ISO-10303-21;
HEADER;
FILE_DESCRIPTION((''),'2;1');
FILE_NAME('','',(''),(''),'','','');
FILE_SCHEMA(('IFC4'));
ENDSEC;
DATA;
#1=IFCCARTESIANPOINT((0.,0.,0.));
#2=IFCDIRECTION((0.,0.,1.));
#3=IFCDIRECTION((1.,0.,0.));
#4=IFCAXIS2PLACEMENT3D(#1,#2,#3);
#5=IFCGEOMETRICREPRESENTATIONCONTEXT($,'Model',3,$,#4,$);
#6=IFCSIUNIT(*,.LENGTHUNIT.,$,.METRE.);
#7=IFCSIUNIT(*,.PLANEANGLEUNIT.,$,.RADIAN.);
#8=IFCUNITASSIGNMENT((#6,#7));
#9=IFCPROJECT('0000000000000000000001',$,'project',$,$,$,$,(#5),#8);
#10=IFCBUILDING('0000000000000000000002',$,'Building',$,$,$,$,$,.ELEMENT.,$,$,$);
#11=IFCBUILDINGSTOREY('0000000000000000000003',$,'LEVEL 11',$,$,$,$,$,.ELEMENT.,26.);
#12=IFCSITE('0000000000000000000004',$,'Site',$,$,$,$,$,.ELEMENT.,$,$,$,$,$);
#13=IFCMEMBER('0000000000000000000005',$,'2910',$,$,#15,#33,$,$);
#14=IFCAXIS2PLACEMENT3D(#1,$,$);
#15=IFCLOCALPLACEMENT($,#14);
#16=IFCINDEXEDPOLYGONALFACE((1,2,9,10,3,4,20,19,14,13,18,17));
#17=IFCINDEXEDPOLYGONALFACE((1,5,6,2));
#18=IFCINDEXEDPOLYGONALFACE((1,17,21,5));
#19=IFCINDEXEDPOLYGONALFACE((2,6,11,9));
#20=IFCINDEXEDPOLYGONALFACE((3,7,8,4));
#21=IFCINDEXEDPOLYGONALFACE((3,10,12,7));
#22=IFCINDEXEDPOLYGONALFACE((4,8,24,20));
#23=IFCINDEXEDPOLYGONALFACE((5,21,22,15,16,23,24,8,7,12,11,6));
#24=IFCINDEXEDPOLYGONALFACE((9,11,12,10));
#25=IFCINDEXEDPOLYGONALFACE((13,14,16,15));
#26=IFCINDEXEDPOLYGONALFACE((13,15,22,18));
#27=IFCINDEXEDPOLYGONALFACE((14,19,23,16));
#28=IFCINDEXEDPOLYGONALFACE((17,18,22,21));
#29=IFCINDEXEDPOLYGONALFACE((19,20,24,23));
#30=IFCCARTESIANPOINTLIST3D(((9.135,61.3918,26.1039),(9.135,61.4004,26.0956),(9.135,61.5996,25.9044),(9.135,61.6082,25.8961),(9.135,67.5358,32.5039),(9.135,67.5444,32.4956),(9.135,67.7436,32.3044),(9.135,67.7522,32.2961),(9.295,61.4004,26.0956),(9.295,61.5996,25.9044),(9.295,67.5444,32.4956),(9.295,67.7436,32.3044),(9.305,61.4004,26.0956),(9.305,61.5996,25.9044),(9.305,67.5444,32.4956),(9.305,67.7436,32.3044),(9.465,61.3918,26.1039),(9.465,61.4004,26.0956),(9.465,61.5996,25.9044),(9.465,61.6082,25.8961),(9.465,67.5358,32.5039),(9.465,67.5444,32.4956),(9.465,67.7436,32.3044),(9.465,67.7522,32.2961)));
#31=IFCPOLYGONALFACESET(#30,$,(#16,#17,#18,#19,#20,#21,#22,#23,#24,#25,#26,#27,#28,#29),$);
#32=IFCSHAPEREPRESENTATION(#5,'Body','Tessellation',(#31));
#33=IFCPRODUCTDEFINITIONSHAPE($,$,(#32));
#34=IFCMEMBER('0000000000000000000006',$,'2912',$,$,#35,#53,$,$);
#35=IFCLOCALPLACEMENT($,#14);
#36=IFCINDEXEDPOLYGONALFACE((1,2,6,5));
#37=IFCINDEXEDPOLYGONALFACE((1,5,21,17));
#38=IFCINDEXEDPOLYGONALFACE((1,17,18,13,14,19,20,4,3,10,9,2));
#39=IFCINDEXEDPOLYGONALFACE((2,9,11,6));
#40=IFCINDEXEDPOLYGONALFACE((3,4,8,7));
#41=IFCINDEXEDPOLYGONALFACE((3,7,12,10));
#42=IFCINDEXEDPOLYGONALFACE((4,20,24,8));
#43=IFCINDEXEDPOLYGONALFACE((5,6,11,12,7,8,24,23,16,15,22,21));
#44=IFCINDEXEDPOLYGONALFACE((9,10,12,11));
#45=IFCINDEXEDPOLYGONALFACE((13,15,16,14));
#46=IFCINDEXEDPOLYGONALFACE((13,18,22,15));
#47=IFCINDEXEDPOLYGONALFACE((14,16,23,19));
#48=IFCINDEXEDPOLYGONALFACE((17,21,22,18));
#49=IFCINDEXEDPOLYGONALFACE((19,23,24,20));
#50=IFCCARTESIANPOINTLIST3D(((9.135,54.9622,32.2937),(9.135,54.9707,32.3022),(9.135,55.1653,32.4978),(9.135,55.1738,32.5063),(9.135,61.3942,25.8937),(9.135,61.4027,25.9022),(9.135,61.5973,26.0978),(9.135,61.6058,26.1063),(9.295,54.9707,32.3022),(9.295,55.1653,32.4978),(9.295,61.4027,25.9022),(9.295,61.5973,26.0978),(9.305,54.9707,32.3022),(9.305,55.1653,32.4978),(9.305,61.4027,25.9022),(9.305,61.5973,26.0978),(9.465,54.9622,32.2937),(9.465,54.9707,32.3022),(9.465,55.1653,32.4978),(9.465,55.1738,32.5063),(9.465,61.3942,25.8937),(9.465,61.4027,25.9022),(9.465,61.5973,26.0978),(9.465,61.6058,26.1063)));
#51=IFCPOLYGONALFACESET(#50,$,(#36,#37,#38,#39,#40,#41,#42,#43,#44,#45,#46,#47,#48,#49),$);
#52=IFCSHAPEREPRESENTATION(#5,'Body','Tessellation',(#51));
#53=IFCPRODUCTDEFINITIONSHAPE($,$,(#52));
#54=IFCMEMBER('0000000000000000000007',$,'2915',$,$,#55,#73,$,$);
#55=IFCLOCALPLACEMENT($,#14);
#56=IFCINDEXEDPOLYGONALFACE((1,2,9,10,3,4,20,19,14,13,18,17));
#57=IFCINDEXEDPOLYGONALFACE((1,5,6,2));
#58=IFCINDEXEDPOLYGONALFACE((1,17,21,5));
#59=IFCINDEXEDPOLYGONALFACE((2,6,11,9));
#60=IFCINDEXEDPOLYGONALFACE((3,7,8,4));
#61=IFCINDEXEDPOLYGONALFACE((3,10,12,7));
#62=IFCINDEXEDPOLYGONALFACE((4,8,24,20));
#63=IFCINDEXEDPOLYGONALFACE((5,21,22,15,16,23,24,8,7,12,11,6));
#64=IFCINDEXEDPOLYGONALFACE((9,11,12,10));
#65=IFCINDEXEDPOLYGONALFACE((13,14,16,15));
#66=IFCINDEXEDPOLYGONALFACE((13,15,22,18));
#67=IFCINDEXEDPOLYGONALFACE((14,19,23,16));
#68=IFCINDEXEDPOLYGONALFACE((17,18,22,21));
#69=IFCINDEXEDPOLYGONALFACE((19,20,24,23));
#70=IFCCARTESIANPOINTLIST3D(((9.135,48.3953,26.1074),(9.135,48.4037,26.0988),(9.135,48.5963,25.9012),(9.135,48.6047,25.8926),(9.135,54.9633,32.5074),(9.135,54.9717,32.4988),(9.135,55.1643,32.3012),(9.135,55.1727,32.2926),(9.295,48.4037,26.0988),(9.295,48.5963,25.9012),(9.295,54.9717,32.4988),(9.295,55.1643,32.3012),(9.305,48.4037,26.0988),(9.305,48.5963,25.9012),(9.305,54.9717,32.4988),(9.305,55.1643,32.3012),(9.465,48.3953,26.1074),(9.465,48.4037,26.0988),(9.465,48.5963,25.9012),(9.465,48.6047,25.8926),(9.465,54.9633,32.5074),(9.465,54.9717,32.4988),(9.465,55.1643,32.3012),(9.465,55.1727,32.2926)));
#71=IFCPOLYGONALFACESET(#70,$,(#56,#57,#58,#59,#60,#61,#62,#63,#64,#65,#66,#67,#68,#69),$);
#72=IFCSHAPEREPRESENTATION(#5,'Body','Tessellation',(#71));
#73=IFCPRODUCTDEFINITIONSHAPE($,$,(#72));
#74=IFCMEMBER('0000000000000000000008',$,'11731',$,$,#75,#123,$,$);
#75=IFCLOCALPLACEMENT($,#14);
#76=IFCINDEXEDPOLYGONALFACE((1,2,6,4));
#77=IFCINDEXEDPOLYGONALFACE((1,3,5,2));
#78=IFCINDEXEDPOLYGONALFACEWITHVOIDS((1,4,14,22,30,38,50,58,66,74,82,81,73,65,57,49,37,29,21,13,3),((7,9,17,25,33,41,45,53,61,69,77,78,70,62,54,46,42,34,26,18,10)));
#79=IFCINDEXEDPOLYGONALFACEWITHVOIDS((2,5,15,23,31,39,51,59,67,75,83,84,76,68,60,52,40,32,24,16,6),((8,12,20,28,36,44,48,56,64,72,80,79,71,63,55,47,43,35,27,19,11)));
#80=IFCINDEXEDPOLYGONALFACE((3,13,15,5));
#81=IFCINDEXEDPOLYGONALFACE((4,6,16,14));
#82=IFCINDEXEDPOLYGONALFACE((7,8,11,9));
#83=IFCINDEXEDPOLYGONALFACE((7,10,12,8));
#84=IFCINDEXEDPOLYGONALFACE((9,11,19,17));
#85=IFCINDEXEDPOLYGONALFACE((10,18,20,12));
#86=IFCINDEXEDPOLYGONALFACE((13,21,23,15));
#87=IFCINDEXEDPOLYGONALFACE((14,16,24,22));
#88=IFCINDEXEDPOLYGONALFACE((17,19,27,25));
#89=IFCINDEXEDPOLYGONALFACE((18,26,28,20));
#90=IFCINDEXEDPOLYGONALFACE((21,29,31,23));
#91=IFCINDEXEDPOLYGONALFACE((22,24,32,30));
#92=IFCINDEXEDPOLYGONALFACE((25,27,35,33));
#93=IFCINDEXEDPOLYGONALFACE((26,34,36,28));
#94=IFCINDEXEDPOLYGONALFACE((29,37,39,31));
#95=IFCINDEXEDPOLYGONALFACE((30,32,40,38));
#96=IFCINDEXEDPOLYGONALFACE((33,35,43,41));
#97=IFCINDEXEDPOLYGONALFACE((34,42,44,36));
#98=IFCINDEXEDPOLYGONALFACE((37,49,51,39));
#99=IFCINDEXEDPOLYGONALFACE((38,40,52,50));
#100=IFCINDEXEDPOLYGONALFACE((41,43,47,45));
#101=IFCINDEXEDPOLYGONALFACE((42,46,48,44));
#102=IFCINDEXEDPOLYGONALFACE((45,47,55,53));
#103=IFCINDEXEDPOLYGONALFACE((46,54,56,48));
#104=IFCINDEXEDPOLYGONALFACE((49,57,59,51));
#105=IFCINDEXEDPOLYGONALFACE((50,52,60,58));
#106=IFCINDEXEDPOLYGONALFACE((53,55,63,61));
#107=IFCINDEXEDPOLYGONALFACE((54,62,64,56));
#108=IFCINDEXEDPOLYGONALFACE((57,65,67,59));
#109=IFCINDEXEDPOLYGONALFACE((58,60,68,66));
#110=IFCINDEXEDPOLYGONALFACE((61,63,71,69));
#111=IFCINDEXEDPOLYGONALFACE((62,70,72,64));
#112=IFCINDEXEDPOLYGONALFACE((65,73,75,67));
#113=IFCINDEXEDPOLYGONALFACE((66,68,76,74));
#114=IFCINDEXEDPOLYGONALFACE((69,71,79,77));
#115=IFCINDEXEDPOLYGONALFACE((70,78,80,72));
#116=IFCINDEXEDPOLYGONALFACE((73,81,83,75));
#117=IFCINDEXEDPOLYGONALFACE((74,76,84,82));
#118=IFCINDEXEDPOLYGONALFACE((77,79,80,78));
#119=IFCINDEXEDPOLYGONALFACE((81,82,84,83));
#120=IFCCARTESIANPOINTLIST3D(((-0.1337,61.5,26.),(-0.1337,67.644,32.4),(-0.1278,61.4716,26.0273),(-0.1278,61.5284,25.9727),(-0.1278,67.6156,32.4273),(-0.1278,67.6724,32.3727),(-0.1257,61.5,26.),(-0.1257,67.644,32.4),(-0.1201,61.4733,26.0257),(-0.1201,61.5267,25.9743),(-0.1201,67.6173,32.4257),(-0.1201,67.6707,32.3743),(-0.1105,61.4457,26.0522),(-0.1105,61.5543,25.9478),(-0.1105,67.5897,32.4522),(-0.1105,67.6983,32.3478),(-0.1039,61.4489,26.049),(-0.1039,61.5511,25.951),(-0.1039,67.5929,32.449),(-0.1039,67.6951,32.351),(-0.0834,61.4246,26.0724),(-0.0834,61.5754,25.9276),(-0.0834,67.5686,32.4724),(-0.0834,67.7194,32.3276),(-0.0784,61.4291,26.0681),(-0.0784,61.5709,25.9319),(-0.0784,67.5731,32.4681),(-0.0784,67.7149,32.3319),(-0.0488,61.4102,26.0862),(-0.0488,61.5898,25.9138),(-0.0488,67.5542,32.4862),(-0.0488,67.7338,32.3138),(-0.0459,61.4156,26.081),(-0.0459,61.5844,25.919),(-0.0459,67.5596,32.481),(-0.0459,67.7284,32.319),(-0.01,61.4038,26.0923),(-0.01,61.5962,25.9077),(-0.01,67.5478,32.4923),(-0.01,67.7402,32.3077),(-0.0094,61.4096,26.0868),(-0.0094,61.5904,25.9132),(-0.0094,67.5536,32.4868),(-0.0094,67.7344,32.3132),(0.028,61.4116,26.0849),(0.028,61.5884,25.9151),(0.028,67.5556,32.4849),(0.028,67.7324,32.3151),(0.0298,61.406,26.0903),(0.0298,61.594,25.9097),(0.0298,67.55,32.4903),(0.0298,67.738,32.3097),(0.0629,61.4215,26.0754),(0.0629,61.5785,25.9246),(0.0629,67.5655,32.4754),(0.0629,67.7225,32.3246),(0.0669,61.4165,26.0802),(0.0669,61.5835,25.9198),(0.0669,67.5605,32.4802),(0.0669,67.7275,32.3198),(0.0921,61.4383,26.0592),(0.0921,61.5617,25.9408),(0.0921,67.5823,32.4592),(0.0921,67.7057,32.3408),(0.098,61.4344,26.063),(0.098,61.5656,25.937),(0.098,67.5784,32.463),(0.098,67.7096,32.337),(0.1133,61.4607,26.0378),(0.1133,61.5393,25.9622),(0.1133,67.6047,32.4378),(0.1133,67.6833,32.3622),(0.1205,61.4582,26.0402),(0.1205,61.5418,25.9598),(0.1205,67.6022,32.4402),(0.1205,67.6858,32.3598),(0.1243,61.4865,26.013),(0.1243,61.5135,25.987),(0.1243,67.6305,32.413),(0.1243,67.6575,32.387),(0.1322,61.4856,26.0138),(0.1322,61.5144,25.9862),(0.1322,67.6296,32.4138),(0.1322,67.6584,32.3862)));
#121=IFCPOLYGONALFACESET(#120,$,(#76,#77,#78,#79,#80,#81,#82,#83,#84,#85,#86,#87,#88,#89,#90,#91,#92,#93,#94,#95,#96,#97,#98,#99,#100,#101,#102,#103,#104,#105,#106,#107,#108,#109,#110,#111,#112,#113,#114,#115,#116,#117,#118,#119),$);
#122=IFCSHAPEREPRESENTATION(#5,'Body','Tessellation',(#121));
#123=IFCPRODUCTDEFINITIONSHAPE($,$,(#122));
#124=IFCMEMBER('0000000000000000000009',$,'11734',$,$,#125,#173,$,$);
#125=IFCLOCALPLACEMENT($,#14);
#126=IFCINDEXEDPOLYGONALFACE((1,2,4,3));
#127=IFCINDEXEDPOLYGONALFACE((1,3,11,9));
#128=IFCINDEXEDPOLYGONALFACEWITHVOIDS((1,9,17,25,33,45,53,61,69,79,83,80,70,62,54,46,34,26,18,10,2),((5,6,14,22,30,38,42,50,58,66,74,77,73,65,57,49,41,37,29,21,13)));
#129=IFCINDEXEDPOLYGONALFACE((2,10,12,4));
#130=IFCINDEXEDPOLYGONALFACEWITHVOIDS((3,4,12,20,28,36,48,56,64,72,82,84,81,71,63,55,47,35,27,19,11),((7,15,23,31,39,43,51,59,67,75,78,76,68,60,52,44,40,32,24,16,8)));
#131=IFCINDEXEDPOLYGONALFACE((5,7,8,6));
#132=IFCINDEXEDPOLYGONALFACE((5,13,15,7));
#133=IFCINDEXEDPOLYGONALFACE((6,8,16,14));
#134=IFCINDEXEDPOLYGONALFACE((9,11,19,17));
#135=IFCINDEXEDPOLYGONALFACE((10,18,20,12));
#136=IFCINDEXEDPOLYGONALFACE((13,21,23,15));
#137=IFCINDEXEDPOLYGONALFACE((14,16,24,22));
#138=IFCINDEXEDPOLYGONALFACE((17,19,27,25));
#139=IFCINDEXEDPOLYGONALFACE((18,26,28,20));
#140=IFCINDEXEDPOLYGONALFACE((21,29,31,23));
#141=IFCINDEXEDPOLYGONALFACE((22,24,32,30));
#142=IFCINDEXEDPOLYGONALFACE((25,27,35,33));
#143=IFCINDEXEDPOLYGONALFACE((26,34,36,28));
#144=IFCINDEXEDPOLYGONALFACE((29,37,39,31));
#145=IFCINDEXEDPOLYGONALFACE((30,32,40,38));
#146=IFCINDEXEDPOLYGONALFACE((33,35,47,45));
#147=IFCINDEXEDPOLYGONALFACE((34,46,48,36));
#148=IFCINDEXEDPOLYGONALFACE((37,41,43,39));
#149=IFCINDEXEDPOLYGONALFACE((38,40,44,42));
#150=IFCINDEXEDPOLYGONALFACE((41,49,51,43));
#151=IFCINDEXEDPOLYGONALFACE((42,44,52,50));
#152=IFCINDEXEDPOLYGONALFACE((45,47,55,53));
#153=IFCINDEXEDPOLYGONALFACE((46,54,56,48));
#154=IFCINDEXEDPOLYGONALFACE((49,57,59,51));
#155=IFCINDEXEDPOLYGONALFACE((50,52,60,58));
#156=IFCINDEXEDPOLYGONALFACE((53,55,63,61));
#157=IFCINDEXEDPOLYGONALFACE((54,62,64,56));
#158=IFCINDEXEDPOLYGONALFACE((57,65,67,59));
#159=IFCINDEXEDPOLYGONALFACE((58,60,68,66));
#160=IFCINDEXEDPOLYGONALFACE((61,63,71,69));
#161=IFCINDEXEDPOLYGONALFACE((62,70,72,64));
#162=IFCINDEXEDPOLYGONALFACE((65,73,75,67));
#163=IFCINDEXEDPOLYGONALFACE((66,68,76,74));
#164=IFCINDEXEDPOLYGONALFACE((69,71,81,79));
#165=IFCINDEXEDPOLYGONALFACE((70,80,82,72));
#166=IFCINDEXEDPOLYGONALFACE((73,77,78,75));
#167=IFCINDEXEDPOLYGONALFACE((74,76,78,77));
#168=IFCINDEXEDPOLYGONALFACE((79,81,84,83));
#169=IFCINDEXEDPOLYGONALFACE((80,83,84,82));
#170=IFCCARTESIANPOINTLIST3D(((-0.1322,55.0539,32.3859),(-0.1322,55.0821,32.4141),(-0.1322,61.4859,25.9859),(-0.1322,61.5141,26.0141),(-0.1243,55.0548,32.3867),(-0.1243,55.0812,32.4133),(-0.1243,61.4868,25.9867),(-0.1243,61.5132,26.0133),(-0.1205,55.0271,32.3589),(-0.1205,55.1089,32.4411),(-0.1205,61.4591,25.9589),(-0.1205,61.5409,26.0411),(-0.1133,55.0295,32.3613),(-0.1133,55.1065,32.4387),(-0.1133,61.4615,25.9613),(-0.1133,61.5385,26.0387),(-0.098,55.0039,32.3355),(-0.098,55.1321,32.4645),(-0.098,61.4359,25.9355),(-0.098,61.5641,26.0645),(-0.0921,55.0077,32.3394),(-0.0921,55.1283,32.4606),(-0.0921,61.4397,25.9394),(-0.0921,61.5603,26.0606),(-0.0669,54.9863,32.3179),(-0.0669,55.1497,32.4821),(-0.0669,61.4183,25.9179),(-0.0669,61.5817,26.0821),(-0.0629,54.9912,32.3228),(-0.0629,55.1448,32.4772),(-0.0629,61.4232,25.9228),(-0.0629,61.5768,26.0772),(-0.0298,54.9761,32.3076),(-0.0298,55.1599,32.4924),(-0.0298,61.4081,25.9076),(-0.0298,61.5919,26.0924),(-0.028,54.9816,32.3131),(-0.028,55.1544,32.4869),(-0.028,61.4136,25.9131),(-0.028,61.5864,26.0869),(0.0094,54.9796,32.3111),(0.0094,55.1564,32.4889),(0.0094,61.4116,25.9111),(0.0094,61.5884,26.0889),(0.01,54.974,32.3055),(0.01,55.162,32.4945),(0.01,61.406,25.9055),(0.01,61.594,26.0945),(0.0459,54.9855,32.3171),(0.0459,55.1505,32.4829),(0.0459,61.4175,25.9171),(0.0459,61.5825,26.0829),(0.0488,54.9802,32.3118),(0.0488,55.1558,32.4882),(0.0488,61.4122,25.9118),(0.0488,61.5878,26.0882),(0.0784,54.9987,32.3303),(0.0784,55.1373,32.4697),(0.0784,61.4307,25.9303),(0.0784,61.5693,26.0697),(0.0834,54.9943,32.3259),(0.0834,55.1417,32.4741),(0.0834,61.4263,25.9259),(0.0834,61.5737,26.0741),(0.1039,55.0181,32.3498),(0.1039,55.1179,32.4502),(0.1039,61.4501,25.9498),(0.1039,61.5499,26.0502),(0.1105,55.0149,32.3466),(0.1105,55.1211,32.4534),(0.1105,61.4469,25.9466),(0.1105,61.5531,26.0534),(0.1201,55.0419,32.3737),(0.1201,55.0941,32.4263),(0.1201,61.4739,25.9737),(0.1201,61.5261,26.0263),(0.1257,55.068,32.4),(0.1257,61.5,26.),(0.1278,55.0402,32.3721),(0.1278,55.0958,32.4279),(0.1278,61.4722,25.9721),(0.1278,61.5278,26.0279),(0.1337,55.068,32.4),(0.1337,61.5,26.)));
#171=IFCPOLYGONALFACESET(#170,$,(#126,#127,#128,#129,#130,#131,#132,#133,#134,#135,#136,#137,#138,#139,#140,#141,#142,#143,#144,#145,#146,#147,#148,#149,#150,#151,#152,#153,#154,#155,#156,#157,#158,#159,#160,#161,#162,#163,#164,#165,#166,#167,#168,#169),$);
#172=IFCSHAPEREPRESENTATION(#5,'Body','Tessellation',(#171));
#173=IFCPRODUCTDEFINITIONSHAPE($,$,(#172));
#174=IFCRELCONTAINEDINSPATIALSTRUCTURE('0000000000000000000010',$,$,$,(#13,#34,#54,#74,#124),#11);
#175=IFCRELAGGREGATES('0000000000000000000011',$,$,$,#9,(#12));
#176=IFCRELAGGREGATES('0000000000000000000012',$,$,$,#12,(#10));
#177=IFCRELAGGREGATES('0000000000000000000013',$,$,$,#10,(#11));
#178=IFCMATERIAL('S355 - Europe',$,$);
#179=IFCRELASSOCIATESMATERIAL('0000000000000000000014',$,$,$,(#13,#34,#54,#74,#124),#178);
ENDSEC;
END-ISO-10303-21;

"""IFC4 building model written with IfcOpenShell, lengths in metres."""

from ifc_helpers import new_model, si_unit, frame, origin_with_axes, origin_2d_with_axis, place, context, project, spatial, hollow_circle, i_section, extrude, material, material_profile, profile_set, profile_usage, element, save


model = new_model("IFC4")

# Units and contexts
model_context = context("Model", 3, world=origin_with_axes())
ifc_project = project(units=[si_unit("LENGTHUNIT", "METRE"), si_unit("PLANEANGLEUNIT", "RADIAN")], contexts=[model_context])

# Site, building, storey
site = spatial("IfcSite", under=ifc_project, Name="Site", CompositionType="ELEMENT")
building = spatial("IfcBuilding", under=site, Name="Building", CompositionType="ELEMENT")
storey = spatial("IfcBuildingStorey", under=building, Name="LEVEL 11", CompositionType="ELEMENT", Elevation=26.0)

# Shared definitions
ifc_material = material(Name="S355 - Europe")

# Members
ifc_material_profile_1 = material_profile(ifc_material, i_section(OverallWidth=0.33, OverallDepth=0.3, WebThickness=0.01, FlangeThickness=0.012, at=origin_2d_with_axis()))
ifc_profile_set_1 = profile_set([ifc_material_profile_1])
ifc_profile_usage_1 = profile_usage(ifc_profile_set_1, cardinal=10)
member_1_placement = place(None, frame((9.3, 61.5, 26.0), z_axis=(0.0, 0.692532, 0.721387), x_axis=(-1.0, 0.0, 0.0)))
element("IfcMember", 1, at=member_1_placement, inside=storey, material=ifc_profile_usage_1, Name="2910", context=model_context, shape_type="SweptSolid", body=[
    extrude(i_section(OverallWidth=0.33, OverallDepth=0.3, WebThickness=0.01, FlangeThickness=0.012, at=origin_2d_with_axis()), origin_with_axes(), (0.0, 0.0, 1.0), 8.8718),
])
ifc_material_profile_2 = material_profile(ifc_material, i_section(OverallWidth=0.33, OverallDepth=0.3, WebThickness=0.01, FlangeThickness=0.012, at=origin_2d_with_axis()))
ifc_profile_set_2 = profile_set([ifc_material_profile_2])
ifc_profile_usage_2 = profile_usage(ifc_profile_set_2, cardinal=10)
member_2_placement = place(None, frame((9.3, 61.5, 26.0), z_axis=(0.0, -0.708868, 0.705341), x_axis=(1.0, 0.0, 0.0)))
element("IfcMember", 2, at=member_2_placement, inside=storey, material=ifc_profile_usage_2, Name="2912", context=model_context, shape_type="SweptSolid", body=[
    extrude(i_section(OverallWidth=0.33, OverallDepth=0.3, WebThickness=0.01, FlangeThickness=0.012, at=origin_2d_with_axis()), origin_with_axes(), (0.0, 0.0, 1.0), 9.0736),
])
ifc_material_profile_3 = material_profile(ifc_material, i_section(OverallWidth=0.33, OverallDepth=0.3, WebThickness=0.01, FlangeThickness=0.012, at=origin_2d_with_axis()))
ifc_profile_set_3 = profile_set([ifc_material_profile_3])
ifc_profile_usage_3 = profile_usage(ifc_profile_set_3, cardinal=10)
member_3_placement = place(None, frame((9.3, 55.068, 32.4), z_axis=(0.0, -0.716207, -0.697888), x_axis=(1.0, 0.0, 0.0)))
element("IfcMember", 3, at=member_3_placement, inside=storey, material=ifc_profile_usage_3, Name="2915", context=model_context, shape_type="SweptSolid", body=[
    extrude(i_section(OverallWidth=0.33, OverallDepth=0.3, WebThickness=0.01, FlangeThickness=0.012, at=origin_2d_with_axis()), origin_with_axes(), (0.0, 0.0, 1.0), 9.1705),
])
ifc_material_profile_4 = material_profile(ifc_material, hollow_circle(Radius=0.1337, WallThickness=0.008, at=origin_2d_with_axis()))
ifc_profile_set_4 = profile_set([ifc_material_profile_4])
ifc_profile_usage_4 = profile_usage(ifc_profile_set_4, cardinal=10)
member_4_placement = place(None, frame((0.0, 61.5, 26.0), z_axis=(0.0, 0.692532, 0.721387), x_axis=(-1.0, 0.0, 0.0)))
element("IfcMember", 4, at=member_4_placement, inside=storey, material=ifc_profile_usage_4, Name="11731", context=model_context, shape_type="SweptSolid", body=[
    extrude(hollow_circle(Radius=0.1337, WallThickness=0.008, at=origin_2d_with_axis()), origin_with_axes(), (0.0, 0.0, 1.0), 8.8718),
])
ifc_material_profile_5 = material_profile(ifc_material, hollow_circle(Radius=0.1337, WallThickness=0.008, at=origin_2d_with_axis()))
ifc_profile_set_5 = profile_set([ifc_material_profile_5])
ifc_profile_usage_5 = profile_usage(ifc_profile_set_5, cardinal=10)
member_5_placement = place(None, frame((0.0, 61.5, 26.0), z_axis=(0.0, -0.708868, 0.705341), x_axis=(1.0, 0.0, 0.0)))
element("IfcMember", 5, at=member_5_placement, inside=storey, material=ifc_profile_usage_5, Name="11734", context=model_context, shape_type="SweptSolid", body=[
    extrude(hollow_circle(Radius=0.1337, WallThickness=0.008, at=origin_2d_with_axis()), origin_with_axes(), (0.0, 0.0, 1.0), 9.0736),
])

save(model, "model.ifc")
